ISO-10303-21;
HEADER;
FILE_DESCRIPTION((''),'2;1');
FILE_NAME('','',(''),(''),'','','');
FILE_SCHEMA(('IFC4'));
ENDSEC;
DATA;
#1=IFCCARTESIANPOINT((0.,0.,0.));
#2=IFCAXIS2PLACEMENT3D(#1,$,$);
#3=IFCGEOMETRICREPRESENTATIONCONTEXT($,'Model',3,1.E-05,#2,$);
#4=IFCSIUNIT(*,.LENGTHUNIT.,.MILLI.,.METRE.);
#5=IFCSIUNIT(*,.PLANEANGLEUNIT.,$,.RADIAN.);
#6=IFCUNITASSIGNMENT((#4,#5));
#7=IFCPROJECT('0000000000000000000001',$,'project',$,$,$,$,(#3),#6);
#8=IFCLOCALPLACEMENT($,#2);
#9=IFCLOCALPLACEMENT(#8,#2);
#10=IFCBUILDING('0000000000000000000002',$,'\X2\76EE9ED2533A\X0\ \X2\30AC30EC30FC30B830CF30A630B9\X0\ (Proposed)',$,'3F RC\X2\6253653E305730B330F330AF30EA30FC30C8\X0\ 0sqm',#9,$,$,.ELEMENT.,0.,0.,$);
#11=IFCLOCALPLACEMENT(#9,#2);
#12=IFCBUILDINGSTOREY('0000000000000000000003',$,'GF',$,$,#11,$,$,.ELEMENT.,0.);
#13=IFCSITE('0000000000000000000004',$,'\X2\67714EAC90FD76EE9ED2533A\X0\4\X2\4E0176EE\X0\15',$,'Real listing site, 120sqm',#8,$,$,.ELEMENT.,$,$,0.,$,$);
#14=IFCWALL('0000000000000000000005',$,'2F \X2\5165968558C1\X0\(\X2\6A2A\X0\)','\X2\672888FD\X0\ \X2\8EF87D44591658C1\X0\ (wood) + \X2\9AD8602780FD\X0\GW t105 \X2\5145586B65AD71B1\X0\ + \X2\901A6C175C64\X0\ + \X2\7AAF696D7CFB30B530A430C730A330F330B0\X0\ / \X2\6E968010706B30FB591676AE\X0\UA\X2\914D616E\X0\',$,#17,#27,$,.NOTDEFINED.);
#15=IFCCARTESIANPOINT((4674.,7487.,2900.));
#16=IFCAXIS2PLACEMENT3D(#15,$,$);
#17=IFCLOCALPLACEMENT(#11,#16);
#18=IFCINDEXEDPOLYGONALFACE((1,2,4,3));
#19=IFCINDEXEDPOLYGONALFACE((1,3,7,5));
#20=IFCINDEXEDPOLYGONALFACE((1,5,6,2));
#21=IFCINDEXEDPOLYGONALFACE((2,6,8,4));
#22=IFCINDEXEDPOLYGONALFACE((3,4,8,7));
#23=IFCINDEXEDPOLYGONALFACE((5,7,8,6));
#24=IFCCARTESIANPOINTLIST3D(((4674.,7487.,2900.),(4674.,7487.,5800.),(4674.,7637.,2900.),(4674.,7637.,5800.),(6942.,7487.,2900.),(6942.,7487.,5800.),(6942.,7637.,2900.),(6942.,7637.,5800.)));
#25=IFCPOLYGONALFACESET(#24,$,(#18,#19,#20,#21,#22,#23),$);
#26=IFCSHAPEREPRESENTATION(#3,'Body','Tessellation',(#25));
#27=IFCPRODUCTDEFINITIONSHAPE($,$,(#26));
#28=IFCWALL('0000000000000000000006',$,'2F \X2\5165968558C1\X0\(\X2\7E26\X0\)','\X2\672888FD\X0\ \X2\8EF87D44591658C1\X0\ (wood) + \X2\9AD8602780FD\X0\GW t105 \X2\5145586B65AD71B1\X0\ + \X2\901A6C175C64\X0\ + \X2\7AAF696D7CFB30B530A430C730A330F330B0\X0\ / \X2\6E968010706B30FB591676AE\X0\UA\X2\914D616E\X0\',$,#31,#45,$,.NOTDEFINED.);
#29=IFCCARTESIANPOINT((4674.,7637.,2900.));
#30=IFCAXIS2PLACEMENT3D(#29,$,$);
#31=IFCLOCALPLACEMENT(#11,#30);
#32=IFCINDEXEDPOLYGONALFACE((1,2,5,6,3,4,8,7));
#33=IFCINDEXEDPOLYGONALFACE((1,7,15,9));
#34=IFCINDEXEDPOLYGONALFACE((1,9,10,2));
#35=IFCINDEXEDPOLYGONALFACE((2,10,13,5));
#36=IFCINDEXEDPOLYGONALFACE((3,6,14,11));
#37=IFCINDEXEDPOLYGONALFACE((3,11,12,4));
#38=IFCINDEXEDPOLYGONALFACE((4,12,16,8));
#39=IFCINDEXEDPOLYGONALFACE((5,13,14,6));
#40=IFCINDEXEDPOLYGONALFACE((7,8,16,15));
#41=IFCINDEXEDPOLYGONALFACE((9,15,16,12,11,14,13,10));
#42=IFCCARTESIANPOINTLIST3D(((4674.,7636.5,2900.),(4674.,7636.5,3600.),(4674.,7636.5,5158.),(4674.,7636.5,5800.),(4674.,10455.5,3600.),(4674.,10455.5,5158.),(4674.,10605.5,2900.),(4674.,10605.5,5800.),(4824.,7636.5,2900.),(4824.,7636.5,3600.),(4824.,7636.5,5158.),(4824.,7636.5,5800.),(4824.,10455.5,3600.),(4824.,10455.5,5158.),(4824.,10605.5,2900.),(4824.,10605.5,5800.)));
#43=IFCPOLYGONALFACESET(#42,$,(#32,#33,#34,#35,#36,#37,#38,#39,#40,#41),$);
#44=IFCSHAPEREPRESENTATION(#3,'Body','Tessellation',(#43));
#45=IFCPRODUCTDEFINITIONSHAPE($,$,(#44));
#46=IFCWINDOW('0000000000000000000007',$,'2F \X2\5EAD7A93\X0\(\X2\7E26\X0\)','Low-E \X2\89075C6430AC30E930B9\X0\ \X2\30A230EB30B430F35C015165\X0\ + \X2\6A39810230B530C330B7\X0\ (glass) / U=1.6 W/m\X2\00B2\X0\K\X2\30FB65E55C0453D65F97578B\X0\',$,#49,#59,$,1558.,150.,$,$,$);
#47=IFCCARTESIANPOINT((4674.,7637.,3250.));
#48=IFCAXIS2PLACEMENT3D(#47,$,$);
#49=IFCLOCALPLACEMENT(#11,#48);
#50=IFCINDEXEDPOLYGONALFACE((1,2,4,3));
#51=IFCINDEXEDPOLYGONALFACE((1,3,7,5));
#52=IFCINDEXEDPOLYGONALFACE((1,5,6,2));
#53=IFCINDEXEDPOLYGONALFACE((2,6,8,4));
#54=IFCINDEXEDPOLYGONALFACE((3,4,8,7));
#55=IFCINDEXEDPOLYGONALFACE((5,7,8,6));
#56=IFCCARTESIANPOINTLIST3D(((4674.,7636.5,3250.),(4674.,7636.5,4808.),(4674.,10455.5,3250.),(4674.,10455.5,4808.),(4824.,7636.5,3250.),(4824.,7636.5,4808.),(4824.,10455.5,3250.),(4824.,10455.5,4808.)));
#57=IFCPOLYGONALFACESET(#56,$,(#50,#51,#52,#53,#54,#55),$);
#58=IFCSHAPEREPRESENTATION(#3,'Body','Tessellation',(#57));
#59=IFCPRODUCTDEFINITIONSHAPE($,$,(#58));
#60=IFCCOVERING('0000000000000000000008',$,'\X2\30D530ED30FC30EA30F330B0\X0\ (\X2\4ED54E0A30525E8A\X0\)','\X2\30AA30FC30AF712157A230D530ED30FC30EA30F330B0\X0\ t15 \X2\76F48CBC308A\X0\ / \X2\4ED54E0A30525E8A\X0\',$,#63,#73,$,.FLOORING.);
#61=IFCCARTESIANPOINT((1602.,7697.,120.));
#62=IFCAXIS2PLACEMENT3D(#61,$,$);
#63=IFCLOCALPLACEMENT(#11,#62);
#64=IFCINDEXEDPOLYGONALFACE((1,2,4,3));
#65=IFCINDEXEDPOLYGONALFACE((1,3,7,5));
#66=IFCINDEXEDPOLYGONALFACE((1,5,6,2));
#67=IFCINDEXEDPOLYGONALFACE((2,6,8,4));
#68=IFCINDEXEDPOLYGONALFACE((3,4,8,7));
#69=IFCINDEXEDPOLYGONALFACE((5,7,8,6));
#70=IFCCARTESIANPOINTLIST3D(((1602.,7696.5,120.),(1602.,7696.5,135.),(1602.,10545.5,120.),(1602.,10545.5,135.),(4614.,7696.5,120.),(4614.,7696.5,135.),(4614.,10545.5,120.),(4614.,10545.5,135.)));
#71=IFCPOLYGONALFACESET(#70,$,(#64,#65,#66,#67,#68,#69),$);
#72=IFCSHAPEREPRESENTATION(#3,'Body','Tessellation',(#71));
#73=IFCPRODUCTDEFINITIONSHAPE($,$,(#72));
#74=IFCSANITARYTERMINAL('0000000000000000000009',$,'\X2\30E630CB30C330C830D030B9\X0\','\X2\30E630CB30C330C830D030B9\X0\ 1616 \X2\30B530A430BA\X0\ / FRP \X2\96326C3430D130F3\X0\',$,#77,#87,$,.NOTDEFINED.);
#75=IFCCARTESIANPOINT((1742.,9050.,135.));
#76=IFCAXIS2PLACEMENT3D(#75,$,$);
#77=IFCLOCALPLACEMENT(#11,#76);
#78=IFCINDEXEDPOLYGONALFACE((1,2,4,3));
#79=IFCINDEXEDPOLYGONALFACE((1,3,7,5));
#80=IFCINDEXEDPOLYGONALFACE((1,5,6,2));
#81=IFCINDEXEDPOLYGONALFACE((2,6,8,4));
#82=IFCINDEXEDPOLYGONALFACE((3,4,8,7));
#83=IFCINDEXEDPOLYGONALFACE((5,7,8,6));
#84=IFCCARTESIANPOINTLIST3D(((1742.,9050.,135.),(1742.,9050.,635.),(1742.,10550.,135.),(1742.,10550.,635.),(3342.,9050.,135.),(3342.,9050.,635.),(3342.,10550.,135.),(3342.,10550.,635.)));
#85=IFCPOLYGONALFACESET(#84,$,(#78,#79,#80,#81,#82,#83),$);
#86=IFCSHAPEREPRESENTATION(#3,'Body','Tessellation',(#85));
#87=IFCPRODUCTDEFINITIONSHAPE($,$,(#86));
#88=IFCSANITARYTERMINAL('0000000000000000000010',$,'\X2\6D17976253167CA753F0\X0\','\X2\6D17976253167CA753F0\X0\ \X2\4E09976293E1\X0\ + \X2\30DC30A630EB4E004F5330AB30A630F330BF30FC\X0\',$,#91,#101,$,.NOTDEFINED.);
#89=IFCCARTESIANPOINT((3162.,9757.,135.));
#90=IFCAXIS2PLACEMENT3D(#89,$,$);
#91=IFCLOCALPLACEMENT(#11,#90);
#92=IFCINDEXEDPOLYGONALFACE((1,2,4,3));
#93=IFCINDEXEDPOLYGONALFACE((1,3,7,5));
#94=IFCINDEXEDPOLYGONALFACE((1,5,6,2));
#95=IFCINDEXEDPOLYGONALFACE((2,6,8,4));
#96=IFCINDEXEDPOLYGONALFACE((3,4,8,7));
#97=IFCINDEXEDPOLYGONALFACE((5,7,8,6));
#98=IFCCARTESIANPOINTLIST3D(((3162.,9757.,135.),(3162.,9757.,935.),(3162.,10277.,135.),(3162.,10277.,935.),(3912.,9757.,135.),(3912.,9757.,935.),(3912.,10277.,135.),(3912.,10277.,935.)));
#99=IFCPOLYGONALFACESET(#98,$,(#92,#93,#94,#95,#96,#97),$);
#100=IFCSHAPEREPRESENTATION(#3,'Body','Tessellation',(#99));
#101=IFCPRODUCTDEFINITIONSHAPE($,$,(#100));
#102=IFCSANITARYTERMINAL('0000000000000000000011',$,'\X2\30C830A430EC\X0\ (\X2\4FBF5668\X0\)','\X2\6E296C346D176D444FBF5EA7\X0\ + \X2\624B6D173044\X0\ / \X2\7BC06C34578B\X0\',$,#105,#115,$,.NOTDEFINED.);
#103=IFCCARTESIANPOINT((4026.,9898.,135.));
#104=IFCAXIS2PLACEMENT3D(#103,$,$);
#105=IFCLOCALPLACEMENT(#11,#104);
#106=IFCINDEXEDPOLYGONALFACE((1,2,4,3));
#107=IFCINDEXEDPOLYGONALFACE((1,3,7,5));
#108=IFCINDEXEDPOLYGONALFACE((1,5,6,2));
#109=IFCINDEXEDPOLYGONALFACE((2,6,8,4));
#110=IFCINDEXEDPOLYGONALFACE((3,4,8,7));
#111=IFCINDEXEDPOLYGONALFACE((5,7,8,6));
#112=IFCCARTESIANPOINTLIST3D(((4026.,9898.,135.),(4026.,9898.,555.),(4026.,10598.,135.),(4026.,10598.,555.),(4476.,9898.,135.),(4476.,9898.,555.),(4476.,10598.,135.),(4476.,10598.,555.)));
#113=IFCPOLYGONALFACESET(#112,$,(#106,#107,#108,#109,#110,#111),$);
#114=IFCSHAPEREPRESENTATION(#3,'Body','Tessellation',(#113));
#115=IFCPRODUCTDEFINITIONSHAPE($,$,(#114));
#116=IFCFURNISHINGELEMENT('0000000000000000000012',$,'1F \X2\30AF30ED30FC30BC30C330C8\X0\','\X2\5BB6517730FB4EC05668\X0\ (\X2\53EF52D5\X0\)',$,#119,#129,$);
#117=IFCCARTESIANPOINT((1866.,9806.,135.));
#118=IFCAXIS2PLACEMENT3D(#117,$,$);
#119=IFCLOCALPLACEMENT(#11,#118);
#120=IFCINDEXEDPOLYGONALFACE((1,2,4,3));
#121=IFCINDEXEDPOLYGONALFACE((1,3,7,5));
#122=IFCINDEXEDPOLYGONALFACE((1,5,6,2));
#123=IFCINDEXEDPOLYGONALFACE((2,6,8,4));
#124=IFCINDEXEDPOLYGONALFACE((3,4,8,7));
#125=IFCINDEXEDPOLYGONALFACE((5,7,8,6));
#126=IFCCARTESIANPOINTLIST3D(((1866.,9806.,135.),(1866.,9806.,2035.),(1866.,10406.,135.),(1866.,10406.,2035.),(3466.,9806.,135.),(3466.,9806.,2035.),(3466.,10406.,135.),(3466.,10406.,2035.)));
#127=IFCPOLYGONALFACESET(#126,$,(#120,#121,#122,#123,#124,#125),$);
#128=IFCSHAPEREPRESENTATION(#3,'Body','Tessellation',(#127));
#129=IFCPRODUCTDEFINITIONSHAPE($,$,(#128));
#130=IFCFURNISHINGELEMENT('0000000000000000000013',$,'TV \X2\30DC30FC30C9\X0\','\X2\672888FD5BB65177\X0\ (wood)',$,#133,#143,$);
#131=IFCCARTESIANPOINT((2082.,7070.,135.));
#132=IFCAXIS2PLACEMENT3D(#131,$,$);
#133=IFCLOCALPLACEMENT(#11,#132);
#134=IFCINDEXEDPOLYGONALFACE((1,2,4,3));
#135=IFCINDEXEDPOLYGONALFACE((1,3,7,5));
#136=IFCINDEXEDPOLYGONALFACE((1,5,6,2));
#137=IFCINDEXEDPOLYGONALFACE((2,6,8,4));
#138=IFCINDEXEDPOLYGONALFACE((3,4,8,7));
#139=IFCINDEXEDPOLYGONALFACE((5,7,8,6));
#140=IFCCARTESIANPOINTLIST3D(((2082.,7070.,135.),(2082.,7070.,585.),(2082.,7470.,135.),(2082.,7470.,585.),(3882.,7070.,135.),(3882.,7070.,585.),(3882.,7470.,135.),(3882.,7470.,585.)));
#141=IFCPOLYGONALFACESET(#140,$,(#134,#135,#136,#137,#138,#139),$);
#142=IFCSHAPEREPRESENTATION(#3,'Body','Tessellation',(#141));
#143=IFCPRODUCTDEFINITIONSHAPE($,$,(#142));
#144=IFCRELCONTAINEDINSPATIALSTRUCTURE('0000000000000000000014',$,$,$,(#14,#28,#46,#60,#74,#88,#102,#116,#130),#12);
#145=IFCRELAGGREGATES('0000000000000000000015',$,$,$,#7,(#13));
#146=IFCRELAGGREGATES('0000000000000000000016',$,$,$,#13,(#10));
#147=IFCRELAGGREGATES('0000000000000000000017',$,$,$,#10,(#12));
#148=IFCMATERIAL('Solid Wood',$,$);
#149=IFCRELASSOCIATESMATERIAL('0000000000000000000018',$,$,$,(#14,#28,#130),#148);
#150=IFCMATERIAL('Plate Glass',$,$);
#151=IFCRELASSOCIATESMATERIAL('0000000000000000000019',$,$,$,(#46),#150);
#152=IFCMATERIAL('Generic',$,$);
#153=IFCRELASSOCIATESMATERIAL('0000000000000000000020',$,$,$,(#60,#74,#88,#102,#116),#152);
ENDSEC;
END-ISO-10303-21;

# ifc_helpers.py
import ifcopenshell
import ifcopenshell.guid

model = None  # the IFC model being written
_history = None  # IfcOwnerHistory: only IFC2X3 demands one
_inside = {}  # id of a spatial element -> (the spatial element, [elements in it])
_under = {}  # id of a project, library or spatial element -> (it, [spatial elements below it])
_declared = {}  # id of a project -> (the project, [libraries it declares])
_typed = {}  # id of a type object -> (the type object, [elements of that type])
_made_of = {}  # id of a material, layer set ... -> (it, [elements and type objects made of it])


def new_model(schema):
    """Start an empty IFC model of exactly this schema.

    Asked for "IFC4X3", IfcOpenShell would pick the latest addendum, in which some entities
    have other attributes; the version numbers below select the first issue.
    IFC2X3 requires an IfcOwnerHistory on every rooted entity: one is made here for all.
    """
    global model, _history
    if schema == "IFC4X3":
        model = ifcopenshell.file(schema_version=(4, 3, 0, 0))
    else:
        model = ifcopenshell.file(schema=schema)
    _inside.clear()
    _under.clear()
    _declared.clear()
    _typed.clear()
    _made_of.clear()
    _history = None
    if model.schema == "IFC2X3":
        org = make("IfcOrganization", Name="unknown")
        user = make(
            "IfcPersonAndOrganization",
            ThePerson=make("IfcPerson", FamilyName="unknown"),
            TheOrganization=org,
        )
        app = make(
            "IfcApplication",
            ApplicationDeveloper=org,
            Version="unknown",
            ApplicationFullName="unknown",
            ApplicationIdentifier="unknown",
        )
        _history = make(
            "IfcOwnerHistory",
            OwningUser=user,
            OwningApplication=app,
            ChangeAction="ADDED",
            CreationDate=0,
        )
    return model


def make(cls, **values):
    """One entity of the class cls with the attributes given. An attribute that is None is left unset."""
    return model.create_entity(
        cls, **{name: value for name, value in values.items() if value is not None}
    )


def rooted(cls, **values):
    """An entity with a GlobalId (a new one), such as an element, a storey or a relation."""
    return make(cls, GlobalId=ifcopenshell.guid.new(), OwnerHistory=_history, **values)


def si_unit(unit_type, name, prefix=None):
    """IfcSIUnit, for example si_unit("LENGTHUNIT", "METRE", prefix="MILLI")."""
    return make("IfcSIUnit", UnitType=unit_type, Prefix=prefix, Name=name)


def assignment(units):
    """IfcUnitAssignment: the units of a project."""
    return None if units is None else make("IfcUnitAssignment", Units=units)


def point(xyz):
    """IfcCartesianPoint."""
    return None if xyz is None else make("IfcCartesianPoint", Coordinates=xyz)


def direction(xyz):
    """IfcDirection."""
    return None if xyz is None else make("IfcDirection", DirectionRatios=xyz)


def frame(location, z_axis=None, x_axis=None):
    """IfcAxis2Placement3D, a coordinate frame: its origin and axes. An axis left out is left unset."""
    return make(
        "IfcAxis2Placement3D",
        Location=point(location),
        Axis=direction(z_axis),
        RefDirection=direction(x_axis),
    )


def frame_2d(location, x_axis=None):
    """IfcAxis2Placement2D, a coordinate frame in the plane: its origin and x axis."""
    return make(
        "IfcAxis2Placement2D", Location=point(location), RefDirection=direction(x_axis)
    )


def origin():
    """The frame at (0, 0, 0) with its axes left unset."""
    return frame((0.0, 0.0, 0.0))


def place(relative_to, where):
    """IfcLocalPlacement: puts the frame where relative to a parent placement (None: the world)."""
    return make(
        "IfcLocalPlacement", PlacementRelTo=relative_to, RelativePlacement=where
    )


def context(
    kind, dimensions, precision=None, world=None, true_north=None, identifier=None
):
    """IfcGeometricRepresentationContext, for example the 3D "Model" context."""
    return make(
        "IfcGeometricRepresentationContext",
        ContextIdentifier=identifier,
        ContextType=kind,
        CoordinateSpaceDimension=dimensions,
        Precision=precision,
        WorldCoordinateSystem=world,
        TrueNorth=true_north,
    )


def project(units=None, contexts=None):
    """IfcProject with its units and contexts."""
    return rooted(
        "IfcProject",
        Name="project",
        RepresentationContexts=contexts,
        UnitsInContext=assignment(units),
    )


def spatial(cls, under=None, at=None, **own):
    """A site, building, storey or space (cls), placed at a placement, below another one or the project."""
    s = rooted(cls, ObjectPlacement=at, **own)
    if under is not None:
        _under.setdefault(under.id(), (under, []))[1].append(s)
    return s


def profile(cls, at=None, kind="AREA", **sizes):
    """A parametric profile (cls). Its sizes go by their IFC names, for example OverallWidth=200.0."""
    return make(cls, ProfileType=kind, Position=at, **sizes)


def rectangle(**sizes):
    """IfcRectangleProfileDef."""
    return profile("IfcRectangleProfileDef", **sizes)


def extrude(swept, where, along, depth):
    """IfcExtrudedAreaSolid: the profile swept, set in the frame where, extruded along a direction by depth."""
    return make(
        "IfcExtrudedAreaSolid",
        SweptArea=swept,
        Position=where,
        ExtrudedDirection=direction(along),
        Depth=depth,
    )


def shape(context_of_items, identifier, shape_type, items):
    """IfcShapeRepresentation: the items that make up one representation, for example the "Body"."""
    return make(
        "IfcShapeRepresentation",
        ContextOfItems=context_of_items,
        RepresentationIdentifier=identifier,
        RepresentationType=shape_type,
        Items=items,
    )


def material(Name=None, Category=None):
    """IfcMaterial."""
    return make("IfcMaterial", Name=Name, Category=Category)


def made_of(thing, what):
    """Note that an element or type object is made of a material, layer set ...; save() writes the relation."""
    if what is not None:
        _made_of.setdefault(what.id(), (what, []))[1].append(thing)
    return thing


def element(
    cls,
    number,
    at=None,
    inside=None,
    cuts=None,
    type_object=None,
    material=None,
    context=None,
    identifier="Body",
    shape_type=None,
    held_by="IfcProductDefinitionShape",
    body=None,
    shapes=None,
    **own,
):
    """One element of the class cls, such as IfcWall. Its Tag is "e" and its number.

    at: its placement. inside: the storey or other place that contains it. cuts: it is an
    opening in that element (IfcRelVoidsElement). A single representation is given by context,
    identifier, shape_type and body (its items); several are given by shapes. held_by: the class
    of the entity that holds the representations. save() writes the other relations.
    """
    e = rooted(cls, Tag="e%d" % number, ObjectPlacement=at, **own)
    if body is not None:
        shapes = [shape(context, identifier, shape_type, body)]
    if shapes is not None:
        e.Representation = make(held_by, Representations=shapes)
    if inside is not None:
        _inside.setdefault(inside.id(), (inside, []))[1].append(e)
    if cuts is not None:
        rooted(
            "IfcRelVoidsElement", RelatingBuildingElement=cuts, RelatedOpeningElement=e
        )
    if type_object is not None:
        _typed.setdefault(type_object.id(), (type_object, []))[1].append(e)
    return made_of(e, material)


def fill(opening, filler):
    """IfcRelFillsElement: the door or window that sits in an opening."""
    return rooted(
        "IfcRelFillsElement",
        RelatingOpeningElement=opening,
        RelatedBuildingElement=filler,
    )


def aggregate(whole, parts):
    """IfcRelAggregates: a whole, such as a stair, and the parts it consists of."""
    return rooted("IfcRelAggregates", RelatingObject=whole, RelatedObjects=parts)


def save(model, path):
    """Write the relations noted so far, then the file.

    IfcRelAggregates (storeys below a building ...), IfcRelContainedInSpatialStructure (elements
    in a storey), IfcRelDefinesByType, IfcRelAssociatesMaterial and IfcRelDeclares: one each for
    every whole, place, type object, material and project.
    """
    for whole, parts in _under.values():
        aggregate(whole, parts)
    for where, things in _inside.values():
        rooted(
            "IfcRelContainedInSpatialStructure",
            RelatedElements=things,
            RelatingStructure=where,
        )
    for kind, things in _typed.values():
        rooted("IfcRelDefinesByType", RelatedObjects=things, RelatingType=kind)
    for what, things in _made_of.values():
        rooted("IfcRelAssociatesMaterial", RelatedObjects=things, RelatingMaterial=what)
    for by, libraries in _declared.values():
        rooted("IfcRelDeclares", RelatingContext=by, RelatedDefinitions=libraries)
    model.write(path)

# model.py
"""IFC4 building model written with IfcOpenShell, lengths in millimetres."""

from ifc_helpers import new_model, si_unit, frame, frame_2d, origin, place, context, project, spatial, rectangle, extrude, material, element, fill, save


model = new_model("IFC4")

# Units and contexts
model_context = context("Model", 3, precision=1e-05, world=origin())
ifc_project = project(units=[si_unit("LENGTHUNIT", "METRE", prefix="MILLI"), si_unit("PLANEANGLEUNIT", "RADIAN")], contexts=[model_context])

# Site, building, storey
site_placement = place(None, origin())
site = spatial("IfcSite", under=ifc_project, at=site_placement, Name="東京都目黒区4丁目15", ObjectType="Real listing site, 120sqm", CompositionType="ELEMENT", RefElevation=0.0)
building_placement = place(site_placement, origin())
building = spatial("IfcBuilding", under=site, at=building_placement, Name="目黒区 ガレージハウス (Proposed)", ObjectType="3F RC打放しコンクリート 0sqm", CompositionType="ELEMENT", ElevationOfRefHeight=0.0, ElevationOfTerrain=0.0)
storey_placement = place(building_placement, origin())
storey = spatial("IfcBuildingStorey", under=building, at=storey_placement, Name="GF", CompositionType="ELEMENT", Elevation=0.0)

# Shared definitions
ifc_material_1 = material(Name="Solid Wood")

# Shared definitions
ifc_material_2 = material(Name="Plate Glass")

# Wall
wall_1_placement = place(storey_placement, frame((4674.0, 7487.0, 2900.0)))
element("IfcWall", 1, at=wall_1_placement, inside=storey, material=ifc_material_1, Name="2F 入隅壁(横)", Description="木製 軸組外壁 (wood) + 高性能GW t105 充填断熱 + 通気層 + 窯業系サイディング / 準耐火・外皮UA配慮", PredefinedType="NOTDEFINED", context=model_context, shape_type="SweptSolid", body=[
    extrude(rectangle(XDim=2268.0, YDim=150.0, at=frame_2d((1134.0, 75.0))), frame((4674.0, 7487.0, 2900.0)), (0.0, 0.0, 1.0), 2900.0),
])

# Wall, opening, window
wall_2_placement = place(storey_placement, frame((4674.0, 7637.0, 2900.0)))
wall_2 = element("IfcWall", 2, at=wall_2_placement, inside=storey, material=ifc_material_1, Name="2F 入隅壁(縦)", Description="木製 軸組外壁 (wood) + 高性能GW t105 充填断熱 + 通気層 + 窯業系サイディング / 準耐火・外皮UA配慮", PredefinedType="NOTDEFINED", context=model_context, shape_type="SweptSolid", body=[
    extrude(rectangle(XDim=150.0, YDim=2969.0, at=frame_2d((75.0, 1484.0))), frame((4674.0, 7637.0, 2900.0)), (0.0, 0.0, 1.0), 2900.0),
])
opening_1_placement = place(storey_placement, frame((4674.0, 7637.0, 3250.0)))
opening_1 = element("IfcOpeningElement", 3, at=opening_1_placement, cuts=wall_2, PredefinedType="NOTDEFINED", context=model_context, shape_type="SweptSolid", body=[
    extrude(rectangle(XDim=150.0, YDim=2819.0, at=frame_2d((75.0, 1409.0))), frame((4674.0, 7637.0, 3250.0)), (0.0, 0.0, 1.0), 1558.0),
])
window_1_placement = place(storey_placement, frame((4674.0, 7637.0, 3250.0)))
window_1 = element("IfcWindow", 4, at=window_1_placement, inside=storey, material=ifc_material_2, Name="2F 庭窓(縦)", Description="Low-E 複層ガラス アルゴン封入 + 樹脂サッシ (glass) / U=1.6 W/m²K・日射取得型", OverallHeight=1558.0, OverallWidth=150.0, context=model_context, shape_type="SweptSolid", body=[
    extrude(rectangle(XDim=150.0, YDim=2819.0, at=frame_2d((75.0, 1409.0))), frame((4674.0, 7637.0, 3250.0)), (0.0, 0.0, 1.0), 1558.0),
])
fill(opening_1, window_1)

# Covering
ifc_material_3 = material(Name="Generic")
covering_placement = place(storey_placement, frame((1602.0, 7697.0, 120.0)))
element("IfcCovering", 5, at=covering_placement, inside=storey, material=ifc_material_3, Name="フローリング (仕上げ床)", Description="オーク無垢フローリング t15 直貼り / 仕上げ床", PredefinedType="FLOORING", context=model_context, shape_type="SweptSolid", body=[
    extrude(rectangle(XDim=3012.0, YDim=2849.0, at=frame_2d((1506.0, 1424.0))), frame((1602.0, 7697.0, 120.0)), (0.0, 0.0, 1.0), 15.0),
])

# Sanitary terminals
sanitary_terminal_1_placement = place(storey_placement, frame((1742.0, 9050.0, 135.0)))
element("IfcSanitaryTerminal", 6, at=sanitary_terminal_1_placement, inside=storey, material=ifc_material_3, Name="ユニットバス", Description="ユニットバス 1616 サイズ / FRP 防水パン", PredefinedType="NOTDEFINED", context=model_context, shape_type="SweptSolid", body=[
    extrude(rectangle(XDim=1600.0, YDim=1500.0, at=frame_2d((800.0, 750.0))), frame((1742.0, 9050.0, 135.0)), (0.0, 0.0, 1.0), 500.0),
])
sanitary_terminal_2_placement = place(storey_placement, frame((3162.0, 9757.0, 135.0)))
element("IfcSanitaryTerminal", 7, at=sanitary_terminal_2_placement, inside=storey, material=ifc_material_3, Name="洗面化粧台", Description="洗面化粧台 三面鏡 + ボウル一体カウンター", PredefinedType="NOTDEFINED", context=model_context, shape_type="SweptSolid", body=[
    extrude(rectangle(XDim=750.0, YDim=520.0, at=frame_2d((375.0, 260.0))), frame((3162.0, 9757.0, 135.0)), (0.0, 0.0, 1.0), 800.0),
])
sanitary_terminal_3_placement = place(storey_placement, frame((4026.0, 9898.0, 135.0)))
element("IfcSanitaryTerminal", 8, at=sanitary_terminal_3_placement, inside=storey, material=ifc_material_3, Name="トイレ (便器)", Description="温水洗浄便座 + 手洗い / 節水型", PredefinedType="NOTDEFINED", context=model_context, shape_type="SweptSolid", body=[
    extrude(rectangle(XDim=450.0, YDim=700.0, at=frame_2d((225.0, 350.0))), frame((4026.0, 9898.0, 135.0)), (0.0, 0.0, 1.0), 420.0),
])

# Furnishing elements
furnishing_1_placement = place(storey_placement, frame((1866.0, 9806.0, 135.0)))
element("IfcFurnishingElement", 9, at=furnishing_1_placement, inside=storey, material=ifc_material_3, Name="1F クローゼット", Description="家具・什器 (可動)", context=model_context, shape_type="SweptSolid", body=[
    extrude(rectangle(XDim=1600.0, YDim=600.0, at=frame_2d((800.0, 300.0))), frame((1866.0, 9806.0, 135.0)), (0.0, 0.0, 1.0), 1900.0),
])
furnishing_2_placement = place(storey_placement, frame((2082.0, 7070.0, 135.0)))
element("IfcFurnishingElement", 10, at=furnishing_2_placement, inside=storey, material=ifc_material_1, Name="TV ボード", Description="木製家具 (wood)", context=model_context, shape_type="SweptSolid", body=[
    extrude(rectangle(XDim=1800.0, YDim=400.0, at=frame_2d((900.0, 200.0))), frame((2082.0, 7070.0, 135.0)), (0.0, 0.0, 1.0), 450.0),
])

save(model, "model.ifc")
